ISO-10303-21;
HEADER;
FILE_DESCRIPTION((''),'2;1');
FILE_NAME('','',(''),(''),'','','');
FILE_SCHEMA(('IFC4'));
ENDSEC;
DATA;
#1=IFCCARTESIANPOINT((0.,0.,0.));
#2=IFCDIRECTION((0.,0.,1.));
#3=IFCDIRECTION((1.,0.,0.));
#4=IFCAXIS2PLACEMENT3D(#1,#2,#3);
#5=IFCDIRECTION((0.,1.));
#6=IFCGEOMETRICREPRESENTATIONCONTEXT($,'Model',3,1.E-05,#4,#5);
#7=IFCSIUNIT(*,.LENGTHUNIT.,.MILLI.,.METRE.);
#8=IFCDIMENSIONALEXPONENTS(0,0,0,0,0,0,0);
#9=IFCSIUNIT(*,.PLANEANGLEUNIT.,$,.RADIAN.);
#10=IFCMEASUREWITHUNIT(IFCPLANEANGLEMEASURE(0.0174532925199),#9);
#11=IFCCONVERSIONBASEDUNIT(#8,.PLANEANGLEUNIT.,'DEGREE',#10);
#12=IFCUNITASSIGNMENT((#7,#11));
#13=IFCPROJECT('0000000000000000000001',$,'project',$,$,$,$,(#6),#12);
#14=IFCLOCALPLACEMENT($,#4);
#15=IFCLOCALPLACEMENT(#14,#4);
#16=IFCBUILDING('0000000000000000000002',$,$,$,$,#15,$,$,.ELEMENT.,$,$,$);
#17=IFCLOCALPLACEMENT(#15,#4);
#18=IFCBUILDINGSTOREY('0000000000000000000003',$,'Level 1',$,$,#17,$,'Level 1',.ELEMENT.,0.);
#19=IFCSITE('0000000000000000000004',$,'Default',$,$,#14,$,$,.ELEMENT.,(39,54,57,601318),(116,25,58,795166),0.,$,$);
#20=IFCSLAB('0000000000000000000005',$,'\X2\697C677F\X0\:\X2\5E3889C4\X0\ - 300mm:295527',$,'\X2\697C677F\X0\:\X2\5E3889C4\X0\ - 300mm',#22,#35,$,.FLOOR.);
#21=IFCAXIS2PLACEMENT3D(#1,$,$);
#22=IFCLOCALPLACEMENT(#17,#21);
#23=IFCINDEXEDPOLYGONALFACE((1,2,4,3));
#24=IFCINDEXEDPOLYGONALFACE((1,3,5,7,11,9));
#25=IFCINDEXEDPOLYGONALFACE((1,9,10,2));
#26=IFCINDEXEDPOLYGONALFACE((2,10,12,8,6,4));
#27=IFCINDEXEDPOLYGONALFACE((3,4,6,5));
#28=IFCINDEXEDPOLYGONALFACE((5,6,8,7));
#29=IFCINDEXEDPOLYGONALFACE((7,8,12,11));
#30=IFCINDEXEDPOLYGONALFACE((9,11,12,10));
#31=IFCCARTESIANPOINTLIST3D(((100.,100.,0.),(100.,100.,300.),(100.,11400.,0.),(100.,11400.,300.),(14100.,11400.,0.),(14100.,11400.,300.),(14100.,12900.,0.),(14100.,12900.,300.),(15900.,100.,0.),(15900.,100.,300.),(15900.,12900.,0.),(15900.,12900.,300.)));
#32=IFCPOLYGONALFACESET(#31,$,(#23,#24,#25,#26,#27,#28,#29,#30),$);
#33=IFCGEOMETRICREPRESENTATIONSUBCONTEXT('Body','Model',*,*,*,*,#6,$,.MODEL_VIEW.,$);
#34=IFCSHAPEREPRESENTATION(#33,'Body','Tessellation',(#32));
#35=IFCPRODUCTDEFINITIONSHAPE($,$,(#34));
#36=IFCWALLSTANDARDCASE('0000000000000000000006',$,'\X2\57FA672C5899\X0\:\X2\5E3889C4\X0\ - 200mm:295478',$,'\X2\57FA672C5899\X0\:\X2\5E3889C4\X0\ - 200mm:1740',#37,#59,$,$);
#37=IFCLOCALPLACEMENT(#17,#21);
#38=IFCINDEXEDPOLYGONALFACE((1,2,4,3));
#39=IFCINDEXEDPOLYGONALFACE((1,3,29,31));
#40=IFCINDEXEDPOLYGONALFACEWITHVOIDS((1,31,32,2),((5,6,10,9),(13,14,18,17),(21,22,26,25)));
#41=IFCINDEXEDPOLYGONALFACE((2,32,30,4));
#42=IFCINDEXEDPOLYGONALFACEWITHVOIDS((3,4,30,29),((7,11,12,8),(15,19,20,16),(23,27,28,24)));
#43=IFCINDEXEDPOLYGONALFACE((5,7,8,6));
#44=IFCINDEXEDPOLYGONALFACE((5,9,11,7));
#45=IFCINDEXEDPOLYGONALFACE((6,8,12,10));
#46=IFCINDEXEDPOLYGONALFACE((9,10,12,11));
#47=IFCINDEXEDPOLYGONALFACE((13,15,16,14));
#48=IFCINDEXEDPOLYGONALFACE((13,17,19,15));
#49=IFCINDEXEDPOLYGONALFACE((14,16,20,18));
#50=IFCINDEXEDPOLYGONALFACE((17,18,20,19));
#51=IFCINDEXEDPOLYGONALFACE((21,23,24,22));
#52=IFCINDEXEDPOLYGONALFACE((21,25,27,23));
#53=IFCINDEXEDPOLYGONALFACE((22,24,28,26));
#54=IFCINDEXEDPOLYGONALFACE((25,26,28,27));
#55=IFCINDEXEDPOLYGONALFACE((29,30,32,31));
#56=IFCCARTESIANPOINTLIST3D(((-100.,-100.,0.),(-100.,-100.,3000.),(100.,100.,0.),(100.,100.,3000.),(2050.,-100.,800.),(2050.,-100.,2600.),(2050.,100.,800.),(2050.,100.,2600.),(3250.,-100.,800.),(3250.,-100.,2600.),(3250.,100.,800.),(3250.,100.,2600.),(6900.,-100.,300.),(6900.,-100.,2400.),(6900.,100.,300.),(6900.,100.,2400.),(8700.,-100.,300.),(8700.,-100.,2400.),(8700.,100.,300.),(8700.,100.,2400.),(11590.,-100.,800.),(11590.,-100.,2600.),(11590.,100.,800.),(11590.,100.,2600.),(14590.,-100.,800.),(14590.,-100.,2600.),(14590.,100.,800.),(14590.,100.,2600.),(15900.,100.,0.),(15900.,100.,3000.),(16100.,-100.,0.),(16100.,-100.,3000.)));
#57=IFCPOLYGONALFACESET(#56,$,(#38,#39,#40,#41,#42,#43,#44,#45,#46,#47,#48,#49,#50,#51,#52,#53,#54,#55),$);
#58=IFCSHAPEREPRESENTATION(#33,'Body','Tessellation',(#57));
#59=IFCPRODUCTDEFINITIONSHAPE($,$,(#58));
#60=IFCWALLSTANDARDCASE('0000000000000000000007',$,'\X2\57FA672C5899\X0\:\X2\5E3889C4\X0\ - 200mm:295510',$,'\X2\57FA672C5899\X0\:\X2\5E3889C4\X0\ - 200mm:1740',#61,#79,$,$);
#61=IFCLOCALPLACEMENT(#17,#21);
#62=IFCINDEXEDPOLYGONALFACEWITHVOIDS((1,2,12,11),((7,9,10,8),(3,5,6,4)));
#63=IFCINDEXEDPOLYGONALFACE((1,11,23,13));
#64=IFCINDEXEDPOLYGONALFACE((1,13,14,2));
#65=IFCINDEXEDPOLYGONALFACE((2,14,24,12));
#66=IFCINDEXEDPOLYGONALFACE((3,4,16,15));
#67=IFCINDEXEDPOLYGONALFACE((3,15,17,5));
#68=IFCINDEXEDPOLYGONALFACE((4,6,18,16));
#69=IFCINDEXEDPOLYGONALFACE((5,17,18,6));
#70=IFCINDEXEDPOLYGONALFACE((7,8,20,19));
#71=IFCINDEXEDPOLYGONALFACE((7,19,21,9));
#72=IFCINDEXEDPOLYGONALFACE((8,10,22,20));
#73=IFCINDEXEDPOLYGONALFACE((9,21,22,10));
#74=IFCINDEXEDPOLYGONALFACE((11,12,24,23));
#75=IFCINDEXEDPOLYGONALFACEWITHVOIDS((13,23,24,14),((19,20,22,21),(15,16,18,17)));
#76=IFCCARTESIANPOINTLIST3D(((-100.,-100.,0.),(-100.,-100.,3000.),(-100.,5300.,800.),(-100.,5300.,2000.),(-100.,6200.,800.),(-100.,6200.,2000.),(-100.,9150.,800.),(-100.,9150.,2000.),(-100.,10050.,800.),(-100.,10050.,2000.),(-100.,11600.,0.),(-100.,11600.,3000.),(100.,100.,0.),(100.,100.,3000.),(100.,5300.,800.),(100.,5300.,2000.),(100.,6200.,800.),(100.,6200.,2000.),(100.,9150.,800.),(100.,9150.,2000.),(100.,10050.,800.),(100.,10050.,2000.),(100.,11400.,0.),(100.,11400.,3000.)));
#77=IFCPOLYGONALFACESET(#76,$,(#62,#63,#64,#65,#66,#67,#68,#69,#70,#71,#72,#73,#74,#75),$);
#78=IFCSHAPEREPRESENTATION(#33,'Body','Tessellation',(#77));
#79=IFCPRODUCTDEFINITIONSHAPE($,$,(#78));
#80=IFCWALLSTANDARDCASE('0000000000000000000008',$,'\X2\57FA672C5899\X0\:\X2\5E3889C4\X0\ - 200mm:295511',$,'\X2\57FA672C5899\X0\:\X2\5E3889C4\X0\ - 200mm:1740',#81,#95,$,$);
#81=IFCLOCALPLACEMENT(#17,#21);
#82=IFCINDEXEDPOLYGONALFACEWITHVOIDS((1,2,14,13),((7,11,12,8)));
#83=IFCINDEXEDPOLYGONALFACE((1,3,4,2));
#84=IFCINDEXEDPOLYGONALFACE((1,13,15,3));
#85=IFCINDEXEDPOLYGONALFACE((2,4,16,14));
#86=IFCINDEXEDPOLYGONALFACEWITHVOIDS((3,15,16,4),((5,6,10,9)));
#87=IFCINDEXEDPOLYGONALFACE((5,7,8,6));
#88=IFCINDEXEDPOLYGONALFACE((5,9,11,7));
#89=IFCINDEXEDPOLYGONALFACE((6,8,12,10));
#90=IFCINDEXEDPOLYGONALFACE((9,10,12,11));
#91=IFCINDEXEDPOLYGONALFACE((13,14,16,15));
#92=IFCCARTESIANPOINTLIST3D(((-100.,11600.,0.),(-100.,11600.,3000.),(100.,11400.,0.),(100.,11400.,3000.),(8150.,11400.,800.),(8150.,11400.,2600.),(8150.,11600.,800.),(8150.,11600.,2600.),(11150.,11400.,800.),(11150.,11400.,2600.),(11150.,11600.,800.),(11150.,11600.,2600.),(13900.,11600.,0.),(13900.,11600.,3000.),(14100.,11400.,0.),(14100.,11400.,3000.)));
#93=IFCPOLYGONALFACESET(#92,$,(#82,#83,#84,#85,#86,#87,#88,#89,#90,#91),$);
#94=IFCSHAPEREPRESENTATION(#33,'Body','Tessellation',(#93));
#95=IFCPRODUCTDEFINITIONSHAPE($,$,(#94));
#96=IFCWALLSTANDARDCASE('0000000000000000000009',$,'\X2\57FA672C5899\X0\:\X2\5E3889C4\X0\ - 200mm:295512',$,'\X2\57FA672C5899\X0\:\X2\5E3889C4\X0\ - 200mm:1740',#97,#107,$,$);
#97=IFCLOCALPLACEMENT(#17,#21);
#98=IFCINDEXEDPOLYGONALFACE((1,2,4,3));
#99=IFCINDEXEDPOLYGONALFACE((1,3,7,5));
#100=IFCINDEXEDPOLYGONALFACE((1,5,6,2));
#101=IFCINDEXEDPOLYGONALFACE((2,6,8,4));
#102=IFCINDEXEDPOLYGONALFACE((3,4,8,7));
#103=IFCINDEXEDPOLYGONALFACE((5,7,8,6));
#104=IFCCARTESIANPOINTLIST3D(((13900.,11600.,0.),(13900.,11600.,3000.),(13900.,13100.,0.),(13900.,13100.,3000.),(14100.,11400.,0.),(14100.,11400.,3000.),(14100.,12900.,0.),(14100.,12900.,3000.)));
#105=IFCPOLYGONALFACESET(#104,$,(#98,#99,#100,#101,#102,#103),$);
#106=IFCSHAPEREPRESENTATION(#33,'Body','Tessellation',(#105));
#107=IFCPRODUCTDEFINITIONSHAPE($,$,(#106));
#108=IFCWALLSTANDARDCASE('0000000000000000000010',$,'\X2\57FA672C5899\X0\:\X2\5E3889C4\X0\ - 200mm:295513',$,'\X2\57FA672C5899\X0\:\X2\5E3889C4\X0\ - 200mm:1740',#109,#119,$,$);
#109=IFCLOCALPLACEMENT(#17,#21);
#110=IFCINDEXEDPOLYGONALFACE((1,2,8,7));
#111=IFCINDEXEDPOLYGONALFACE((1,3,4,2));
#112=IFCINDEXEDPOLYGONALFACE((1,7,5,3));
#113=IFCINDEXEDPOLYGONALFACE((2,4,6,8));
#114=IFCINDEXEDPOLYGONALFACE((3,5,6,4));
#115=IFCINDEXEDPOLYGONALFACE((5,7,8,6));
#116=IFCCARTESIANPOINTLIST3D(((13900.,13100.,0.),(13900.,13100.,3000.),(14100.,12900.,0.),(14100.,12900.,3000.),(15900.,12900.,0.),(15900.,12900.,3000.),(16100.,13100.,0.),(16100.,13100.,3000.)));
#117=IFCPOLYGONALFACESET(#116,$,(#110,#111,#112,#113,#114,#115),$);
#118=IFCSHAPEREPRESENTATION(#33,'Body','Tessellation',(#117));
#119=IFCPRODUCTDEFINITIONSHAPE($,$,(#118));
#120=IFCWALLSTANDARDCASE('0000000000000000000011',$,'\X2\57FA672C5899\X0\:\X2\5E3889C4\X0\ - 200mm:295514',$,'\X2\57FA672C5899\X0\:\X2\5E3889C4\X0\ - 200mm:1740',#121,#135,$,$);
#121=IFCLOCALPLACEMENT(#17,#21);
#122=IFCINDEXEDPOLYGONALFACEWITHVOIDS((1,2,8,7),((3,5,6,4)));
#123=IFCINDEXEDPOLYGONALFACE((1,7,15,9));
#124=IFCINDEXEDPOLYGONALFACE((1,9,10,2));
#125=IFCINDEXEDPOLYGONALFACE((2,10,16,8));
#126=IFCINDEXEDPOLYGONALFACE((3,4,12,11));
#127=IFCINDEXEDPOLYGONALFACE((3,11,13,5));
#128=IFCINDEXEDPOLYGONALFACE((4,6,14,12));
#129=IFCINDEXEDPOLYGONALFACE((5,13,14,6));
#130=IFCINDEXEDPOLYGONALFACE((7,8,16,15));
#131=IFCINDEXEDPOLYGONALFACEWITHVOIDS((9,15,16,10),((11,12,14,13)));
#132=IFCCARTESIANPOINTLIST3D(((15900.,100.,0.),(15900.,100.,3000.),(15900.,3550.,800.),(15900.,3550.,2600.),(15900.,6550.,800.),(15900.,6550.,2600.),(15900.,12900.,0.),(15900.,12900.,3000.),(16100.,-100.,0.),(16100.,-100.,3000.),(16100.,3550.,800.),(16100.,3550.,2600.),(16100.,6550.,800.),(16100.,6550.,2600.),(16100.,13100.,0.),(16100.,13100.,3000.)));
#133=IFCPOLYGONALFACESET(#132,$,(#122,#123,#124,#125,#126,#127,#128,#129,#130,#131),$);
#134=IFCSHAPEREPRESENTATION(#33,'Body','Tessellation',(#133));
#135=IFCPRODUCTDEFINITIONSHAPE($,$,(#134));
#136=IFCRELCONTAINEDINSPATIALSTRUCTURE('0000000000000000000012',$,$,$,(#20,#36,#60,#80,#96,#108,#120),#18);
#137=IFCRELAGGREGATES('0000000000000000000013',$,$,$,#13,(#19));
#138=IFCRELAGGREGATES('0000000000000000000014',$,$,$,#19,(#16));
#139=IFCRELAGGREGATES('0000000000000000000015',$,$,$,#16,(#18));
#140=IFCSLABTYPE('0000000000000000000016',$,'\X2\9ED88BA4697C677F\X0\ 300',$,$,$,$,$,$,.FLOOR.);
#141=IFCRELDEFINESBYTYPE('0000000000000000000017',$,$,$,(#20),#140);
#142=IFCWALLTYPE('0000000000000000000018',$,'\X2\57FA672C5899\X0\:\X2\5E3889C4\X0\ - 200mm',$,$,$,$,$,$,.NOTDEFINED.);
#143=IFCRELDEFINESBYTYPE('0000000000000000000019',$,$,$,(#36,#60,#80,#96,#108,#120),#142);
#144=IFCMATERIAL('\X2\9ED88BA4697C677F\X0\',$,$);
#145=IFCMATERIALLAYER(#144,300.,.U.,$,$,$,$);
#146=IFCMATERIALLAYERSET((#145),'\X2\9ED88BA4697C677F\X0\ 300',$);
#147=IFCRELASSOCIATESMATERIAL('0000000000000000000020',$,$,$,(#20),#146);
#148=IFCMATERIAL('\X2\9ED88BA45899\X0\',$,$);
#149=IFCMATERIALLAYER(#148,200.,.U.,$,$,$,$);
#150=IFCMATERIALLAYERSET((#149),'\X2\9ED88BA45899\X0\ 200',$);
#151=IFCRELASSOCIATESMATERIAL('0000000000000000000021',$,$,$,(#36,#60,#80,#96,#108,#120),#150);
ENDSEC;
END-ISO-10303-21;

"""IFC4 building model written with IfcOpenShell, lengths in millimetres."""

from ifc_helpers import new_model, entity, si_unit, converted_unit, direction, frame, origin_with_axes, place, context, subcontext, project, spatial, polyline, outline, extrude, material, layer, layer_set, layer_usage, type_object, element, save


model = new_model("IFC4")

# Units and contexts
model_context = context("Model", 3, precision=1e-05, world=origin_with_axes(), true_north=direction((0.0, 1.0)))
body_context = subcontext(model_context, "Body", "Model", "MODEL_VIEW")
ifc_project = project(units=[si_unit("LENGTHUNIT", "METRE", prefix="MILLI"), converted_unit("PLANEANGLEUNIT", "DEGREE", entity("IfcPlaneAngleMeasure", 0.0174532925199), si_unit("PLANEANGLEUNIT", "RADIAN"), dimensions=[0, 0, 0, 0, 0, 0, 0])], contexts=[model_context])

# Site, building, storey
site_placement = place(None, origin_with_axes())
site = spatial("IfcSite", under=ifc_project, at=site_placement, Name="Default", CompositionType="ELEMENT", RefLatitude=(39, 54, 57, 601318), RefLongitude=(116, 25, 58, 795166), RefElevation=0.0)
building_placement = place(site_placement, origin_with_axes())
building = spatial("IfcBuilding", under=site, at=building_placement, CompositionType="ELEMENT")
storey_placement = place(building_placement, origin_with_axes())
storey = spatial("IfcBuildingStorey", under=building, at=storey_placement, Name="Level 1", LongName="Level 1", CompositionType="ELEMENT", Elevation=0.0)

# Slab
ifc_material_1 = material(Name="默认楼板")
ifc_layer_1 = layer(ifc_material_1, 300.0, ventilated="UNKNOWN")
ifc_layer_set_1 = layer_set([ifc_layer_1], Name="默认楼板 300")
ifc_layer_usage_1 = layer_usage(ifc_layer_set_1, "AXIS3", "NEGATIVE", 300.0)
slab_type = type_object("IfcSlabType", Name="默认楼板 300", PredefinedType="FLOOR")
slab_placement = place(storey_placement, frame((100.0, 100.0, 0.0), z_axis=(0.0, 0.0, 1.0), x_axis=(1.0, 0.0, 0.0)))
element("IfcSlab", 1, at=slab_placement, inside=storey, type_object=slab_type, material=ifc_layer_usage_1, Name="楼板:常规 - 300mm:295527", ObjectType="楼板:常规 - 300mm", PredefinedType="FLOOR", context=body_context, shape_type="SweptSolid", body=[
    extrude(outline(polyline([(0.0, 0.0), (15800.0, 0.0), (15800.0, 12800.0), (14000.0, 12800.0), (14000.0, 11300.0), (0.0, 11300.0), (0.0, 0.0)])), origin_with_axes(), (0.0, 0.0, 1.0), 300.0),
])

# Walls, openings
ifc_material_2 = material(Name="默认墙")
ifc_layer_2 = layer(ifc_material_2, 200.0, ventilated="UNKNOWN")
ifc_layer_set_2 = layer_set([ifc_layer_2], Name="默认墙 200")
ifc_layer_usage_2 = layer_usage(ifc_layer_set_2, "AXIS2", "POSITIVE", -100.0)
wall_type = type_object("IfcWallType", Name="基本墙:常规 - 200mm", PredefinedType="NOTDEFINED")
wall_1_placement = place(storey_placement, frame((16000.0, 0.0, 0.0), z_axis=(0.0, 0.0, 1.0), x_axis=(-1.0, 0.0, 0.0)))
wall_1 = element("IfcWallStandardCase", 2, at=wall_1_placement, inside=storey, type_object=wall_type, material=ifc_layer_usage_2, Name="基本墙:常规 - 200mm:295478", ObjectType="基本墙:常规 - 200mm:1740", context=body_context, shape_type="SweptSolid", body=[
    extrude(outline(polyline([(100.0, -100.0), (15900.0, -100.0), (16100.0, 100.0), (-100.0, 100.0), (100.0, -100.0)])), origin_with_axes(), (0.0, 0.0, 1.0), 3000.0),
])
opening_1_placement = place(wall_1_placement, frame((13350.0, 0.0, 800.0), z_axis=(0.0, 0.0, 1.0), x_axis=(1.0, 0.0, 0.0)))
element("IfcOpeningElement", 3, at=opening_1_placement, cuts=wall_1, context=body_context, shape_type="SweptSolid", body=[
    extrude(outline(polyline([(-600.0, 0.0), (-600.0, -1800.0), (600.0, -1800.0), (600.0, 0.0), (-600.0, 0.0)])), frame((0.0, -100.0, 0.0), z_axis=(0.0, 1.0, 0.0), x_axis=(1.0, 0.0, 0.0)), (0.0, 0.0, 1.0), 200.0),
])
opening_2_placement = place(wall_1_placement, frame((2910.0, 0.0, 800.0), z_axis=(0.0, 0.0, 1.0), x_axis=(1.0, 0.0, 0.0)))
element("IfcOpeningElement", 4, at=opening_2_placement, cuts=wall_1, context=body_context, shape_type="SweptSolid", body=[
    extrude(outline(polyline([(-1500.0, 0.0), (-1500.0, -1800.0), (1500.0, -1800.0), (1500.0, 0.0), (-1500.0, 0.0)])), frame((0.0, -100.0, 0.0), z_axis=(0.0, 1.0, 0.0), x_axis=(1.0, 0.0, 0.0)), (0.0, 0.0, 1.0), 200.0),
])
opening_3_placement = place(wall_1_placement, frame((8200.0, 0.0, 300.0), z_axis=(0.0, 0.0, 1.0), x_axis=(1.0, 0.0, 0.0)))
element("IfcOpeningElement", 5, at=opening_3_placement, cuts=wall_1, context=body_context, shape_type="SweptSolid", body=[
    extrude(outline(polyline([(-900.0, 0.0), (-900.0, -2100.0), (900.0, -2100.0), (900.0, 0.0), (-900.0, 0.0)])), frame((0.0, -100.0, 0.0), z_axis=(0.0, 1.0, 0.0), x_axis=(1.0, 0.0, 0.0)), (0.0, 0.0, 1.0), 200.0),
])
ifc_layer_usage_3 = layer_usage(ifc_layer_set_2, "AXIS2", "POSITIVE", -100.0)
wall_2_placement = place(storey_placement, frame((0.0, 0.0, 0.0), z_axis=(0.0, 0.0, 1.0), x_axis=(0.0, 1.0, 0.0)))
wall_2 = element("IfcWallStandardCase", 6, at=wall_2_placement, inside=storey, type_object=wall_type, material=ifc_layer_usage_3, Name="基本墙:常规 - 200mm:295510", ObjectType="基本墙:常规 - 200mm:1740", context=body_context, shape_type="SweptSolid", body=[
    extrude(outline(polyline([(100.0, -100.0), (11400.0, -100.0), (11600.0, 100.0), (-100.0, 100.0), (100.0, -100.0)])), origin_with_axes(), (0.0, 0.0, 1.0), 3000.0),
])
opening_4_placement = place(wall_2_placement, frame((5750.0, 0.0, 800.0), z_axis=(0.0, 0.0, 1.0), x_axis=(1.0, 0.0, 0.0)))
element("IfcOpeningElement", 7, at=opening_4_placement, cuts=wall_2, context=body_context, shape_type="SweptSolid", body=[
    extrude(outline(polyline([(450.0, -1200.0), (450.0, 0.0), (-450.0, 0.0), (-450.0, -1200.0), (450.0, -1200.0)])), frame((0.0, 100.0, 0.0), z_axis=(0.0, -1.0, 0.0), x_axis=(-1.0, 0.0, 0.0)), (0.0, 0.0, 1.0), 200.0),
])
opening_5_placement = place(wall_2_placement, frame((9600.0, 0.0, 800.0), z_axis=(0.0, 0.0, 1.0), x_axis=(1.0, 0.0, 0.0)))
element("IfcOpeningElement", 8, at=opening_5_placement, cuts=wall_2, context=body_context, shape_type="SweptSolid", body=[
    extrude(outline(polyline([(450.0, -1200.0), (450.0, 0.0), (-450.0, 0.0), (-450.0, -1200.0), (450.0, -1200.0)])), frame((0.0, 100.0, 0.0), z_axis=(0.0, -1.0, 0.0), x_axis=(-1.0, 0.0, 0.0)), (0.0, 0.0, 1.0), 200.0),
])

# Wall, opening
ifc_layer_usage_4 = layer_usage(ifc_layer_set_2, "AXIS2", "POSITIVE", -100.0)
wall_3_placement = place(storey_placement, frame((0.0, 11500.0, 0.0), z_axis=(0.0, 0.0, 1.0), x_axis=(1.0, 0.0, 0.0)))
wall_3 = element("IfcWallStandardCase", 9, at=wall_3_placement, inside=storey, type_object=wall_type, material=ifc_layer_usage_4, Name="基本墙:常规 - 200mm:295511", ObjectType="基本墙:常规 - 200mm:1740", context=body_context, shape_type="SweptSolid", body=[
    extrude(outline(polyline([(100.0, -100.0), (14100.0, -100.0), (13900.0, 100.0), (-100.0, 100.0), (100.0, -100.0)])), origin_with_axes(), (0.0, 0.0, 1.0), 3000.0),
])
opening_6_placement = place(wall_3_placement, frame((9650.0, 0.0, 800.0), z_axis=(0.0, 0.0, 1.0), x_axis=(1.0, 0.0, 0.0)))
element("IfcOpeningElement", 10, at=opening_6_placement, cuts=wall_3, context=body_context, shape_type="SweptSolid", body=[
    extrude(outline(polyline([(-1500.0, 0.0), (-1500.0, -1800.0), (1500.0, -1800.0), (1500.0, 0.0), (-1500.0, 0.0)])), frame((0.0, -100.0, 0.0), z_axis=(0.0, 1.0, 0.0), x_axis=(1.0, 0.0, 0.0)), (0.0, 0.0, 1.0), 200.0),
])

# Walls
ifc_layer_usage_5 = layer_usage(ifc_layer_set_2, "AXIS2", "POSITIVE", -100.0)
wall_4_placement = place(storey_placement, frame((14000.0, 11500.0, 0.0), z_axis=(0.0, 0.0, 1.0), x_axis=(0.0, 1.0, 0.0)))
element("IfcWallStandardCase", 11, at=wall_4_placement, inside=storey, type_object=wall_type, material=ifc_layer_usage_5, Name="基本墙:常规 - 200mm:295512", ObjectType="基本墙:常规 - 200mm:1740", context=body_context, shape_type="SweptSolid", body=[
    extrude(outline(polyline([(-100.0, -100.0), (1400.0, -100.0), (1600.0, 100.0), (100.0, 100.0), (-100.0, -100.0)])), origin_with_axes(), (0.0, 0.0, 1.0), 3000.0),
])
ifc_layer_usage_6 = layer_usage(ifc_layer_set_2, "AXIS2", "POSITIVE", -100.0)
wall_5_placement = place(storey_placement, frame((14000.0, 13000.0, 0.0), z_axis=(0.0, 0.0, 1.0), x_axis=(1.0, 0.0, 0.0)))
element("IfcWallStandardCase", 12, at=wall_5_placement, inside=storey, type_object=wall_type, material=ifc_layer_usage_6, Name="基本墙:常规 - 200mm:295513", ObjectType="基本墙:常规 - 200mm:1740", context=body_context, shape_type="SweptSolid", body=[
    extrude(outline(polyline([(100.0, -100.0), (1900.0, -100.0), (2100.0, 100.0), (-100.0, 100.0), (100.0, -100.0)])), origin_with_axes(), (0.0, 0.0, 1.0), 3000.0),
])

# Wall, opening
ifc_layer_usage_7 = layer_usage(ifc_layer_set_2, "AXIS2", "POSITIVE", -100.0)
wall_6_placement = place(storey_placement, frame((16000.0, 13000.0, 0.0), z_axis=(0.0, 0.0, 1.0), x_axis=(0.0, -1.0, 0.0)))
wall_6 = element("IfcWallStandardCase", 13, at=wall_6_placement, inside=storey, type_object=wall_type, material=ifc_layer_usage_7, Name="基本墙:常规 - 200mm:295514", ObjectType="基本墙:常规 - 200mm:1740", context=body_context, shape_type="SweptSolid", body=[
    extrude(outline(polyline([(100.0, -100.0), (12900.0, -100.0), (13100.0, 100.0), (-100.0, 100.0), (100.0, -100.0)])), origin_with_axes(), (0.0, 0.0, 1.0), 3000.0),
])
opening_7_placement = place(wall_6_placement, frame((7950.0, 0.0, 800.0), z_axis=(0.0, 0.0, 1.0), x_axis=(1.0, 0.0, 0.0)))
element("IfcOpeningElement", 14, at=opening_7_placement, cuts=wall_6, context=body_context, shape_type="SweptSolid", body=[
    extrude(outline(polyline([(-1500.0, 0.0), (-1500.0, -1800.0), (1500.0, -1800.0), (1500.0, 0.0), (-1500.0, 0.0)])), frame((0.0, -100.0, 0.0), z_axis=(0.0, 1.0, 0.0), x_axis=(1.0, 0.0, 0.0)), (0.0, 0.0, 1.0), 200.0),
])

save(model, "model.ifc")
